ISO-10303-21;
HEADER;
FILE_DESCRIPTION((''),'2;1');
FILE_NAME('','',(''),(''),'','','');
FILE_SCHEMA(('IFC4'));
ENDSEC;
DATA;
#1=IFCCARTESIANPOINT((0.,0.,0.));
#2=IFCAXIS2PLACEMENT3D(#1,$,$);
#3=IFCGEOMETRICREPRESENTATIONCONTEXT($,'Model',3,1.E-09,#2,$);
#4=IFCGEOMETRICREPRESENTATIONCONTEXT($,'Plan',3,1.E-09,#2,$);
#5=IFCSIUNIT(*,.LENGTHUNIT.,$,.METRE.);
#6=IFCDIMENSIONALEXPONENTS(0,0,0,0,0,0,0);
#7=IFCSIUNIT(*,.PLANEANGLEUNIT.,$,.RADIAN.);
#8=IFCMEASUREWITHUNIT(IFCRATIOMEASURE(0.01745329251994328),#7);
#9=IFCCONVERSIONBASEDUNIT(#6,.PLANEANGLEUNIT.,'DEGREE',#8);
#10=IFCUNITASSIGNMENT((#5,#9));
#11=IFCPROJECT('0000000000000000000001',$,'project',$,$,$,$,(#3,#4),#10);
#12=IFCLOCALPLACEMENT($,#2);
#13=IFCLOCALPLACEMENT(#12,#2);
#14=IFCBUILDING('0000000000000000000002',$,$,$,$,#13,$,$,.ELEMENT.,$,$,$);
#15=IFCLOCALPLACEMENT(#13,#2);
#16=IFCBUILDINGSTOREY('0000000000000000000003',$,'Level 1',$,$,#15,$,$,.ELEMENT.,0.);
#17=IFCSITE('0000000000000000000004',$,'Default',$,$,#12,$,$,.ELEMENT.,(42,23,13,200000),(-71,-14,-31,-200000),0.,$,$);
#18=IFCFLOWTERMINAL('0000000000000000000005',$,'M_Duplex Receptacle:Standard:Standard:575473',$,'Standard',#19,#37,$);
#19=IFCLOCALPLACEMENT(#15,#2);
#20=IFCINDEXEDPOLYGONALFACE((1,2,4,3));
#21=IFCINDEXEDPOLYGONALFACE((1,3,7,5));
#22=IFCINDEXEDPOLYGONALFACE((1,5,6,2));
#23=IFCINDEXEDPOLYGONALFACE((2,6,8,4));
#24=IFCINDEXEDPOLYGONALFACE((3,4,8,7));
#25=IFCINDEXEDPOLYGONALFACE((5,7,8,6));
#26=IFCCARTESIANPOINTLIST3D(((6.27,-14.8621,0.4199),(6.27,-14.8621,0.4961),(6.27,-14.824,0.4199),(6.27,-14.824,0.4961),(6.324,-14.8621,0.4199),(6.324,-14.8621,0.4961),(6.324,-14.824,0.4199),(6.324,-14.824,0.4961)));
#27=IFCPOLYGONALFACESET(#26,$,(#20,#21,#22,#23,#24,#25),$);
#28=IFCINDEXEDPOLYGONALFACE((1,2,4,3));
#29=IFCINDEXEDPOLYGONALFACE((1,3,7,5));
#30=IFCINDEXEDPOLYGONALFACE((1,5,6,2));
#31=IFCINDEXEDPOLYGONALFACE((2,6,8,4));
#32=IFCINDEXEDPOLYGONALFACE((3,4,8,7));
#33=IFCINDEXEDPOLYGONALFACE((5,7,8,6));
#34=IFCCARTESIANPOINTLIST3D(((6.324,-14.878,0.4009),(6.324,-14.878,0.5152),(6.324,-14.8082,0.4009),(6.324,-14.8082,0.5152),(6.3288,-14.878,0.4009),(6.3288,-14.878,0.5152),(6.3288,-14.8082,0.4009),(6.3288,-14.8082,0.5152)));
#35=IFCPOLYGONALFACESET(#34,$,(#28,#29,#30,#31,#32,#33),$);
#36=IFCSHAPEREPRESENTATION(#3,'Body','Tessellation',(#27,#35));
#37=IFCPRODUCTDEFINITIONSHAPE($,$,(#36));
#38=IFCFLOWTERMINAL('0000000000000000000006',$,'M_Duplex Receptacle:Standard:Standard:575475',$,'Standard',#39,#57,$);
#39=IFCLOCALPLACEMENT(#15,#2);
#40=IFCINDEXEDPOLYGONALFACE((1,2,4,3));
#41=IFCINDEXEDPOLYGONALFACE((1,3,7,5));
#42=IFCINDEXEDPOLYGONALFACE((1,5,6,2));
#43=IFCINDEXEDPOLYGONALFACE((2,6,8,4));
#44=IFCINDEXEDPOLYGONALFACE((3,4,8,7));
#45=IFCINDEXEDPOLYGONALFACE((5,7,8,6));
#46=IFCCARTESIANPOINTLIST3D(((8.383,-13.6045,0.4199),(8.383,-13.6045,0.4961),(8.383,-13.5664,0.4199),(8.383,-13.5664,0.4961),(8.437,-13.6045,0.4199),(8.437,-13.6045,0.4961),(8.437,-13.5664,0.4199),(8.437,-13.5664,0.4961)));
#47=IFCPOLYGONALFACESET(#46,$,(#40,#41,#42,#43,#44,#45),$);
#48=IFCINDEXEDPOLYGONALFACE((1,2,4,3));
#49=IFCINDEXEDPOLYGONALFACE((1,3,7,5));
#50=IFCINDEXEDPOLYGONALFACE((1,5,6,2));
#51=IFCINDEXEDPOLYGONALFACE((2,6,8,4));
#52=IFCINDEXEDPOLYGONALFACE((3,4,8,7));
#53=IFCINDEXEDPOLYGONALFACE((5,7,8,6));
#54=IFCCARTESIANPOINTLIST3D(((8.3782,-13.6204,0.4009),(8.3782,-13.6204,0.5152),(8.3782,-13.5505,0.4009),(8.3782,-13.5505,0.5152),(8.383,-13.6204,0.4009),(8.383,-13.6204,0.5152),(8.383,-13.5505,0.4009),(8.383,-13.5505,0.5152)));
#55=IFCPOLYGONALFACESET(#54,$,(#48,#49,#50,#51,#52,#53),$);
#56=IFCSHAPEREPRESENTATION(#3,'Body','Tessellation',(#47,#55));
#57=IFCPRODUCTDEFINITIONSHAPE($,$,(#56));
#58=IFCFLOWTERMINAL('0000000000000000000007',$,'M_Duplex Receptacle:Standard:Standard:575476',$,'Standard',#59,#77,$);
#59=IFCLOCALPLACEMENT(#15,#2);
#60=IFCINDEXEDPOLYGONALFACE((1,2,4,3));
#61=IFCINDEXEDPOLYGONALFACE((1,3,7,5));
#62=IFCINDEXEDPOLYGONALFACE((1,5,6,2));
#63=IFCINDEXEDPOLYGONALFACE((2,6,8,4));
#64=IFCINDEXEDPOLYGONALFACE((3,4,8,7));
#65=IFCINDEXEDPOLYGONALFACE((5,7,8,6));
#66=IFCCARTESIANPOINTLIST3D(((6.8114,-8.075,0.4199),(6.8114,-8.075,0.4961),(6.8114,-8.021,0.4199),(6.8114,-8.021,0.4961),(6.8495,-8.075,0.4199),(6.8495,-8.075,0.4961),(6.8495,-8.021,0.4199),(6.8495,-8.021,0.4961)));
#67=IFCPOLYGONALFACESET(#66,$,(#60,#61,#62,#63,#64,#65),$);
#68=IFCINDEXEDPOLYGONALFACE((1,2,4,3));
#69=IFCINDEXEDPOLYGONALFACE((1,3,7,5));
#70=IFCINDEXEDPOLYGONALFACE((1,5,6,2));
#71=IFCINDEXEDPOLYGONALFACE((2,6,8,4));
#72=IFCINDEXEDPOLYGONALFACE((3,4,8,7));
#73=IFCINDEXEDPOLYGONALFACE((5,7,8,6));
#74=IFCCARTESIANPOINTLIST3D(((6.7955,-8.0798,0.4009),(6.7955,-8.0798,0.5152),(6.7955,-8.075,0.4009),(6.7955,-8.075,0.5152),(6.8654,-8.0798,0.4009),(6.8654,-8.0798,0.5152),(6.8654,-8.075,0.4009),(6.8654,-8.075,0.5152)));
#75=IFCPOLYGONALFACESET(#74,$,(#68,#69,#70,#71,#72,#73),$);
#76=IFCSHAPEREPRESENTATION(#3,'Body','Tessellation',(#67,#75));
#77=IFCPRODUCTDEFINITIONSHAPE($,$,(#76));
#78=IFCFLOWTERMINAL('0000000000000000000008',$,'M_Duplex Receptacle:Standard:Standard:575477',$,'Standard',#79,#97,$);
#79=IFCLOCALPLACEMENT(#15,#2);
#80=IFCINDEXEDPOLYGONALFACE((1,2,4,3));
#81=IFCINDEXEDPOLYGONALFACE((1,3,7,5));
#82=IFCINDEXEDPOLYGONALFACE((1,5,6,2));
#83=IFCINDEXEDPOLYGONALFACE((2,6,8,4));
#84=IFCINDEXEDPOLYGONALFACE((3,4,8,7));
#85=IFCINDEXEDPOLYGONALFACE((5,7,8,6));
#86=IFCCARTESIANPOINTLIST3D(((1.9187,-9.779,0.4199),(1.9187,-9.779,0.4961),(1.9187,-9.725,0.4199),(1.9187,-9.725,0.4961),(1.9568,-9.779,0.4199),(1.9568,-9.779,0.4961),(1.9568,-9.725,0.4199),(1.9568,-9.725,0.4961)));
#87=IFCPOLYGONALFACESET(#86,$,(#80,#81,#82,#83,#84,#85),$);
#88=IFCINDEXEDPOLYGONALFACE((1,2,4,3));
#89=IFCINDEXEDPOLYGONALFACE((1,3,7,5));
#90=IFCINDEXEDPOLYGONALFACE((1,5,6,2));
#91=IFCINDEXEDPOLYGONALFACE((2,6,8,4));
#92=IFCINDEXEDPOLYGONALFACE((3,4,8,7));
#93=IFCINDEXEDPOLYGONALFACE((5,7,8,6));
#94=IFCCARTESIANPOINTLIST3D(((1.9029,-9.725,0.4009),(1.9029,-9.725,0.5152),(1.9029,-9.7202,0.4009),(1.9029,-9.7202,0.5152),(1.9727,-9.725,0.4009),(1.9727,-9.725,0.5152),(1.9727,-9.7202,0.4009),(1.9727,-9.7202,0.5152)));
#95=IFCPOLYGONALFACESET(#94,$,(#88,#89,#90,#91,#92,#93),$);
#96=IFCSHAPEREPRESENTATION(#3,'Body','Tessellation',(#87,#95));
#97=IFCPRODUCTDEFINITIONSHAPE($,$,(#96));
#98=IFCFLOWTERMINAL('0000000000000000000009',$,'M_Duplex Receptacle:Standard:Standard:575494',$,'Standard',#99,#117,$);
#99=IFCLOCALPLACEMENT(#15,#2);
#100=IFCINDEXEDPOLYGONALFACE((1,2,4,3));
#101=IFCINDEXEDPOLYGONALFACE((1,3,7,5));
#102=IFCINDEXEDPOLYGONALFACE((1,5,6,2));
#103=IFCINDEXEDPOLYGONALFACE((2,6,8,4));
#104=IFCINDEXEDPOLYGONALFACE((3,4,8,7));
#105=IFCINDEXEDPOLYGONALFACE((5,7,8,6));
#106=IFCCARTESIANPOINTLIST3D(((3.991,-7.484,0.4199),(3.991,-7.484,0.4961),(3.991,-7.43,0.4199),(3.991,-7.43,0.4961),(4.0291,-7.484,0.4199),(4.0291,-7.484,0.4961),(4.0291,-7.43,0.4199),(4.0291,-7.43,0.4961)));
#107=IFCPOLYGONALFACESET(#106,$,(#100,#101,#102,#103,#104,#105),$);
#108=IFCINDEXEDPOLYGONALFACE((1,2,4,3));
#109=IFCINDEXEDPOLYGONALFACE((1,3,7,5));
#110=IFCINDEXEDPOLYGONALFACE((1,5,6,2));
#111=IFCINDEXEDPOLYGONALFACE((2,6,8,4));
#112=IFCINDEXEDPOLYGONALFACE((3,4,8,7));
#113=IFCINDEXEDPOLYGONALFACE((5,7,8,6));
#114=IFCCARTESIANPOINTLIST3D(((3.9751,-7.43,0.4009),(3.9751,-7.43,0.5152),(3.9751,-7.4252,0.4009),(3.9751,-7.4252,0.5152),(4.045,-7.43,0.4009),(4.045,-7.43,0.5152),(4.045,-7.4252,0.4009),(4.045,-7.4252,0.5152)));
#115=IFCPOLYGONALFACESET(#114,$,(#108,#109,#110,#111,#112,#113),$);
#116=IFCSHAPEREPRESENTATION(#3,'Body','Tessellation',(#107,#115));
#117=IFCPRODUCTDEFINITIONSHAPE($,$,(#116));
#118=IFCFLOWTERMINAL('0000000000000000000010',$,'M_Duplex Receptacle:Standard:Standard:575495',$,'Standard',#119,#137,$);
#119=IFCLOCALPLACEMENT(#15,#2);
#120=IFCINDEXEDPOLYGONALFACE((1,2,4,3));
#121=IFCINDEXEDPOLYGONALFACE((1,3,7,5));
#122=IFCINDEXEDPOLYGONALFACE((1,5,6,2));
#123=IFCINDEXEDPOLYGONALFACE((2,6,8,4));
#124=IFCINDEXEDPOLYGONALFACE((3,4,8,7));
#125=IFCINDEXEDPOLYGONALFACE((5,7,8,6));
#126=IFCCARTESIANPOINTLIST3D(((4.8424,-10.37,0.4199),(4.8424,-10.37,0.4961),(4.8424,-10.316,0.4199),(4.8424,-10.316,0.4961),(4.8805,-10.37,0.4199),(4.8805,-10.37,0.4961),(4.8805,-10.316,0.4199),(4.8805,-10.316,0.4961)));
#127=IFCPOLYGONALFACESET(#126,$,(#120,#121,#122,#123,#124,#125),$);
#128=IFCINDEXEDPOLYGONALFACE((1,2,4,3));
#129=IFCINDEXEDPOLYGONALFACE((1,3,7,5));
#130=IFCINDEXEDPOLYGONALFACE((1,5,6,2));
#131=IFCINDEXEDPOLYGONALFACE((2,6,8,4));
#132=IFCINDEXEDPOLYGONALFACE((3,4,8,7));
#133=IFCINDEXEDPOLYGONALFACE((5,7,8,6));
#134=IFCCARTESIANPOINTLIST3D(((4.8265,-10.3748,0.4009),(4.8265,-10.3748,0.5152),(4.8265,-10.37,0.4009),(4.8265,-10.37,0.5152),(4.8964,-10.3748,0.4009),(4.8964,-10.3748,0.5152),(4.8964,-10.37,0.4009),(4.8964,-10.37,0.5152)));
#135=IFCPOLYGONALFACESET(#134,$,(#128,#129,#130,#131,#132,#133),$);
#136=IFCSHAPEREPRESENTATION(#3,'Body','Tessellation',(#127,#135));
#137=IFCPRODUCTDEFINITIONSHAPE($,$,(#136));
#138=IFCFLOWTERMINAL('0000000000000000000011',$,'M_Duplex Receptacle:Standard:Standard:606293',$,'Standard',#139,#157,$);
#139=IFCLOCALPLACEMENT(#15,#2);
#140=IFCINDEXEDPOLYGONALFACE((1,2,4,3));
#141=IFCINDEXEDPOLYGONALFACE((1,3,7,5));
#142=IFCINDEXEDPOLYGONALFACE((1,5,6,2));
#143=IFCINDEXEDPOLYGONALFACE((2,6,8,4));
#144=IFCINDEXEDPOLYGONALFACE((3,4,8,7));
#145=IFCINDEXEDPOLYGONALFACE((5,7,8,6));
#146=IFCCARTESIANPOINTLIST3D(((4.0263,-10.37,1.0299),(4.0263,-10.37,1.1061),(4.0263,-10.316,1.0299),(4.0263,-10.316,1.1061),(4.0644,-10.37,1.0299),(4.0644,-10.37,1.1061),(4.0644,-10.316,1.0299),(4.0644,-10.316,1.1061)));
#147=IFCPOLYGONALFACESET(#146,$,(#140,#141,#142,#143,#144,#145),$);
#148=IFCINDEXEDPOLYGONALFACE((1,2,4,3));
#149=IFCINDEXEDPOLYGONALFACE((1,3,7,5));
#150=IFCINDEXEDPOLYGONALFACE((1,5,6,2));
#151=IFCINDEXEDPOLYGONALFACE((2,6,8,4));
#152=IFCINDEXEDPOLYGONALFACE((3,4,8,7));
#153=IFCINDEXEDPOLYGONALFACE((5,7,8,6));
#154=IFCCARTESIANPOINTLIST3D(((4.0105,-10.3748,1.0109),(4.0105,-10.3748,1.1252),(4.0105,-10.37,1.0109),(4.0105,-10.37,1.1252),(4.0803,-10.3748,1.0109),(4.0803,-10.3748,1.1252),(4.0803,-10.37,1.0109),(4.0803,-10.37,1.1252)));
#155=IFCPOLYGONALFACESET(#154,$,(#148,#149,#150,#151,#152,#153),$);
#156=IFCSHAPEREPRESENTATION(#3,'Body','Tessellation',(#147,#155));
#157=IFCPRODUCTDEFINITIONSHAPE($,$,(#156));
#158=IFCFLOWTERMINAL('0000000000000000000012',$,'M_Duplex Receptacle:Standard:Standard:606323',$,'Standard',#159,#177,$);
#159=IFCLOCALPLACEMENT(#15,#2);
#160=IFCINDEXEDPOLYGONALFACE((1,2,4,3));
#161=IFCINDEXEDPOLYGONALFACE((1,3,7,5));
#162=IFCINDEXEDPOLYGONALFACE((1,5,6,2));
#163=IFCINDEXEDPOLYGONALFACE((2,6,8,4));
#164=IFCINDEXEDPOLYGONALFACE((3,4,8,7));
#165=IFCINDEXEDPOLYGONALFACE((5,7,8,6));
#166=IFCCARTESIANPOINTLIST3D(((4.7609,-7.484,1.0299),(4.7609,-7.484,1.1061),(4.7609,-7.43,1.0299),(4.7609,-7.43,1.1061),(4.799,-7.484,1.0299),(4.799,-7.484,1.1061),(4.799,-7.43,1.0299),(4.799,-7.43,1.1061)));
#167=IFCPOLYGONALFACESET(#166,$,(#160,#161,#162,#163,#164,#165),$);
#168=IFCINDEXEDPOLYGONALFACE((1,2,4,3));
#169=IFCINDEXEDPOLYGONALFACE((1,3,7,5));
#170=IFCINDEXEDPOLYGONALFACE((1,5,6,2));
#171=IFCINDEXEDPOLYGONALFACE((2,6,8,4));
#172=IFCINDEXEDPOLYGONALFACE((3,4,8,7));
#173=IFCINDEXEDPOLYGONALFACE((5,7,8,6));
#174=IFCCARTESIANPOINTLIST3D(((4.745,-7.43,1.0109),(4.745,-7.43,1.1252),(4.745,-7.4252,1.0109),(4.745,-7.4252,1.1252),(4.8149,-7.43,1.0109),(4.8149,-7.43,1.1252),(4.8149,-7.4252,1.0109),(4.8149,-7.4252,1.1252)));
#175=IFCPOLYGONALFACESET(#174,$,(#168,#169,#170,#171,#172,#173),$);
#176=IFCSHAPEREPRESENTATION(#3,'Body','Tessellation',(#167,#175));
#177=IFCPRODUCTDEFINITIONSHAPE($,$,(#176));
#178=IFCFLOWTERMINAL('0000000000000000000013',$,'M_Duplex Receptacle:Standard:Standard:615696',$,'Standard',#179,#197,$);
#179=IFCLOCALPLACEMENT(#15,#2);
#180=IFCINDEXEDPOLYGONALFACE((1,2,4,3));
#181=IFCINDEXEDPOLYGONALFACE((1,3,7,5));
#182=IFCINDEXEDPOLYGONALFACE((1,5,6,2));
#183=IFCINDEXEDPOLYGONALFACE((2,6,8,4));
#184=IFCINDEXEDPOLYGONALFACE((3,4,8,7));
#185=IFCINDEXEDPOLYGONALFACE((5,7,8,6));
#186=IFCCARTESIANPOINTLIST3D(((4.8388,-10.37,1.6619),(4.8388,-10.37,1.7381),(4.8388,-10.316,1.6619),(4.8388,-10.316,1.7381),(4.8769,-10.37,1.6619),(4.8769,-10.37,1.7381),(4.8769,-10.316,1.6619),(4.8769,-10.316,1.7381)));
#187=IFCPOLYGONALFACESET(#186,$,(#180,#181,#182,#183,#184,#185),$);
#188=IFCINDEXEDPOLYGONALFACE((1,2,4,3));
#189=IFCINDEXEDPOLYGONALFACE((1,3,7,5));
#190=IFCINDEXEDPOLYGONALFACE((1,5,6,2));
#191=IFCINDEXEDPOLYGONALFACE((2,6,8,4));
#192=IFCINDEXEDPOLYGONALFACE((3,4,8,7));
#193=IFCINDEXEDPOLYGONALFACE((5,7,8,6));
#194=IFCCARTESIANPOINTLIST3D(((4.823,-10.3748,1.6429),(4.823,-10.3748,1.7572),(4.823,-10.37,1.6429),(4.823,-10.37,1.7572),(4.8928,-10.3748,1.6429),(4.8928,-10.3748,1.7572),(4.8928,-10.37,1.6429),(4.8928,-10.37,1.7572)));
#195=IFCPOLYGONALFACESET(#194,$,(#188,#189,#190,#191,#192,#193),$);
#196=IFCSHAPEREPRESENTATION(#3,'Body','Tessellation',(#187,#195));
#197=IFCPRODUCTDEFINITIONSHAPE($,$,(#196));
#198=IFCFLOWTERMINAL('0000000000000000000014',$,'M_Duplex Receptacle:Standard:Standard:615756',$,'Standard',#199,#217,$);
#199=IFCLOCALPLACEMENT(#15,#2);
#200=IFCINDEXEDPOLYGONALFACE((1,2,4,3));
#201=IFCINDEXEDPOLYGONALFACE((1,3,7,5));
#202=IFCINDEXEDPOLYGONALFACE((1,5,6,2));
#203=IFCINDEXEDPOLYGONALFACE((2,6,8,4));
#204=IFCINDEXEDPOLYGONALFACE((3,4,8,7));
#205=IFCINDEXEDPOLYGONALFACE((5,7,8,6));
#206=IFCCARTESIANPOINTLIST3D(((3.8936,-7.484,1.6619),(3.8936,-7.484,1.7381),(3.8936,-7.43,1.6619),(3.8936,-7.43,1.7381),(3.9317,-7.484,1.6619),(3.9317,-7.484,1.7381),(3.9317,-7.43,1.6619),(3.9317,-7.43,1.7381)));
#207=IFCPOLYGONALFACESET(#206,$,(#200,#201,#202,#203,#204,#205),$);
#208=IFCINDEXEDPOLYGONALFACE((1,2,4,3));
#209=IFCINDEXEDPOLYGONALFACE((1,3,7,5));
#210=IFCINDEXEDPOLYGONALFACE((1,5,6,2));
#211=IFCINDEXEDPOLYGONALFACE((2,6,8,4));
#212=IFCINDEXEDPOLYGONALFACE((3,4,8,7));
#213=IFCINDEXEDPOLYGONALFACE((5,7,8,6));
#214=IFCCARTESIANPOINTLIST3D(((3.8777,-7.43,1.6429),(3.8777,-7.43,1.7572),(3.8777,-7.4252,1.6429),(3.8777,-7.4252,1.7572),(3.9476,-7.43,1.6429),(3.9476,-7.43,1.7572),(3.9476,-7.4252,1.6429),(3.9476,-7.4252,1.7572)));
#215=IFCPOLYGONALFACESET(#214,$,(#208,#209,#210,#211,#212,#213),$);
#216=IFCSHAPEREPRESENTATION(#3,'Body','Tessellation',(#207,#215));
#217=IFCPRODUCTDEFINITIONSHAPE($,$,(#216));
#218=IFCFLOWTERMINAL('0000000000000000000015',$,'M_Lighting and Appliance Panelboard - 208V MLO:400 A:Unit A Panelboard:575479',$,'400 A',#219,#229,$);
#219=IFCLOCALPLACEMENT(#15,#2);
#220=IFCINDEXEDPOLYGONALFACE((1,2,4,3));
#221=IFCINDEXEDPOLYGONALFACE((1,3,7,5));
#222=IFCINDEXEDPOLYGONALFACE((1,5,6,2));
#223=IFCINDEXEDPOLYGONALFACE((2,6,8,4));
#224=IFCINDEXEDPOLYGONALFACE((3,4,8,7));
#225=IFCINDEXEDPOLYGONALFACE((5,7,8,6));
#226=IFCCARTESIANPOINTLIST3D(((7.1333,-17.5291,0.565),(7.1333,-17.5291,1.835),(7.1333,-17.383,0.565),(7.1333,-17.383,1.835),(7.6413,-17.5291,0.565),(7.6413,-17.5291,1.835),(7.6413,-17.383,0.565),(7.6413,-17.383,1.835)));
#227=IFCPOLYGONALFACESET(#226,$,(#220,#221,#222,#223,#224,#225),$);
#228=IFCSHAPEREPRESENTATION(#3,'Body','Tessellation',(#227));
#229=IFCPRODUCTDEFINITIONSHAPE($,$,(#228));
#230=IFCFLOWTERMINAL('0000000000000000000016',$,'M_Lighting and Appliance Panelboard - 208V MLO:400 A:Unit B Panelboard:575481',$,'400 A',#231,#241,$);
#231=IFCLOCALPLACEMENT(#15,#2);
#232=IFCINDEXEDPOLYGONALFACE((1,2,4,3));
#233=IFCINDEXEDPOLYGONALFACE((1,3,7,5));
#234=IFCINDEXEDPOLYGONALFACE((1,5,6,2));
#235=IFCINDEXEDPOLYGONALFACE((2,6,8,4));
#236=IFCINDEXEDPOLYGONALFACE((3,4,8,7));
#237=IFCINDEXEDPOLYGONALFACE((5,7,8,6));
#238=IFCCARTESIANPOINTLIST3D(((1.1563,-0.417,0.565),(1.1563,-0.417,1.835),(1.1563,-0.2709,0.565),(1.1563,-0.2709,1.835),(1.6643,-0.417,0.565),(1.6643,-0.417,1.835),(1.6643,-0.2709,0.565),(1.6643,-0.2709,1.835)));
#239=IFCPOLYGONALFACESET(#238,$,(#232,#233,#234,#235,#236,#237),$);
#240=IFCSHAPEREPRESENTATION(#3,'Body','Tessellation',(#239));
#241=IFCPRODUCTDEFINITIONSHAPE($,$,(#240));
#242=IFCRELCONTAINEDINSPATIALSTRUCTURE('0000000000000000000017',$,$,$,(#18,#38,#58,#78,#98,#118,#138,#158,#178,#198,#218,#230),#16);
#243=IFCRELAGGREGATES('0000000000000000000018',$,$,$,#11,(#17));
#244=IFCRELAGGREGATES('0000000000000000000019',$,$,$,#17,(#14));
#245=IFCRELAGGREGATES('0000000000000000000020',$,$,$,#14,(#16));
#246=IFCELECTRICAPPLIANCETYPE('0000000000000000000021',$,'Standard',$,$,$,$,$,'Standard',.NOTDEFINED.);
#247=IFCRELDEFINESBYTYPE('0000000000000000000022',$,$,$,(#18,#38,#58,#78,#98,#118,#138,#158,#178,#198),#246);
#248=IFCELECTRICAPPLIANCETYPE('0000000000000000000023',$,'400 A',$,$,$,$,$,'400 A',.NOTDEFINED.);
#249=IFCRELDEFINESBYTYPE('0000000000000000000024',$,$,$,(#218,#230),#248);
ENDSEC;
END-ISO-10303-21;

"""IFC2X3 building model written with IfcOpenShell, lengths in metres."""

from ifc_helpers import new_model, entity, si_unit, converted_unit, frame, origin, origin_2d_with_axis, place, context, project, spatial, rectangle, extrude, source, transform, mapped, type_object, type_shapes, element, save


model = new_model("IFC2X3")

# Units and contexts
model_context = context("Model", 3, precision=1e-09, world=origin())
plan_context = context("Plan", 3, precision=1e-09, world=origin())
ifc_project = project(units=[si_unit("LENGTHUNIT", "METRE"), converted_unit("PLANEANGLEUNIT", "DEGREE", entity("IfcRatioMeasure", 0.01745329251994328), si_unit("PLANEANGLEUNIT", "RADIAN"), dimensions=[0, 0, 0, 0, 0, 0, 0])], contexts=[model_context, plan_context])

# Site, building, storey
site_placement = place(None, origin())
site = spatial("IfcSite", under=ifc_project, at=site_placement, Name="Default", CompositionType="ELEMENT", RefLatitude=(42, 23, 13, 200000), RefLongitude=(-71, -14, -31, -200000), RefElevation=0.0)
building_placement = place(site_placement, origin())
building = spatial("IfcBuilding", under=site, at=building_placement, CompositionType="ELEMENT")
storey_placement = place(building_placement, origin())
storey = spatial("IfcBuildingStorey", under=building, at=storey_placement, Name="Level 1", CompositionType="ELEMENT", Elevation=0.0)

# Flow terminals
electric_appliance_type_1 = type_object("IfcElectricApplianceType", Name="Standard", ElementType="Standard", PredefinedType="NOTDEFINED")
shared_shape_1 = source(origin(), model_context, "Body", "SweptSolid", [
    extrude(rectangle(XDim=0.0381, YDim=0.0762, at=origin_2d_with_axis()), frame((0.0, 0.0, -0.054), z_axis=(0.0, 0.0, 1.0), x_axis=(-1.0, 0.0, 0.0)), (0.0, 0.0, 1.0), 0.054),
    extrude(rectangle(XDim=0.0698, YDim=0.1143, at=origin_2d_with_axis()), frame((0.0, 0.0, 0.0), z_axis=(0.0, 0.0, 1.0), x_axis=(-1.0, 0.0, 0.0)), (0.0, 0.0, 1.0), 0.0048),
])
type_shapes(electric_appliance_type_1, [shared_shape_1])
for number, where, z_axis, x_axis, name in (
    (1, (6.324, -14.8431, 0.458), (1.0, 0.0, 0.0), (0.0, 1.0, 0.0), "M_Duplex Receptacle:Standard:Standard:575473"),
    (2, (8.383, -13.5854, 0.458), (-1.0, 0.0, 0.0), (0.0, -1.0, 0.0), "M_Duplex Receptacle:Standard:Standard:575475"),
    (3, (6.8305, -8.075, 0.458), (0.0, -1.0, 0.0), (1.0, 0.0, 0.0), "M_Duplex Receptacle:Standard:Standard:575476"),
    (4, (1.9378, -9.725, 0.458), (0.0, 1.0, 0.0), (-1.0, 0.0, 0.0), "M_Duplex Receptacle:Standard:Standard:575477"),
    (5, (4.0101, -7.43, 0.458), (0.0, 1.0, 0.0), (-1.0, 0.0, 0.0), "M_Duplex Receptacle:Standard:Standard:575494"),
    (6, (4.8615, -10.37, 0.458), (0.0, -1.0, 0.0), (1.0, 0.0, 0.0), "M_Duplex Receptacle:Standard:Standard:575495"),
    (7, (4.0454, -10.37, 1.068), (0.0, -1.0, 0.0), (1.0, 0.0, 0.0), "M_Duplex Receptacle:Standard:Standard:606293"),
    (8, (4.78, -7.43, 1.068), (0.0, 1.0, 0.0), (-1.0, 0.0, 0.0), "M_Duplex Receptacle:Standard:Standard:606323"),
    (9, (4.8579, -10.37, 1.7), (0.0, -1.0, 0.0), (1.0, 0.0, 0.0), "M_Duplex Receptacle:Standard:Standard:615696"),
    (10, (3.9127, -7.43, 1.7), (0.0, 1.0, 0.0), (-1.0, 0.0, 0.0), "M_Duplex Receptacle:Standard:Standard:615756"),
):
    element("IfcFlowTerminal", number, at=place(storey_placement, frame(where, z_axis=z_axis, x_axis=x_axis)), inside=storey, type_object=electric_appliance_type_1, Name=name, ObjectType="Standard", context=model_context, shape_type="MappedRepresentation", body=[
        mapped(shared_shape_1, transform((0.0, 0.0, 0.0), scale=1.0)),
    ])
electric_appliance_type_2 = type_object("IfcElectricApplianceType", Name="400 A", ElementType="400 A", PredefinedType="NOTDEFINED")
shared_shape_2 = source(origin(), model_context, "Body", "SweptSolid", [
    extrude(rectangle(XDim=0.508, YDim=1.27, at=origin_2d_with_axis()), frame((0.0, -0.4191, -0.1461), z_axis=(0.0, 0.0, 1.0), x_axis=(-1.0, 0.0, 0.0)), (0.0, 0.0, 1.0), 0.1461),
])
type_shapes(electric_appliance_type_2, [shared_shape_2])
for number, where, z_axis, x_axis, name in (
    (11, (7.3873, -17.383, 1.6191), (0.0, 1.0, 0.0), (-1.0, 0.0, 0.0), "M_Lighting and Appliance Panelboard - 208V MLO:400 A:Unit A Panelboard:575479"),
    (12, (1.4103, -0.417, 1.6191), (0.0, -1.0, 0.0), (1.0, 0.0, 0.0), "M_Lighting and Appliance Panelboard - 208V MLO:400 A:Unit B Panelboard:575481"),
):
    element("IfcFlowTerminal", number, at=place(storey_placement, frame(where, z_axis=z_axis, x_axis=x_axis)), inside=storey, type_object=electric_appliance_type_2, Name=name, ObjectType="400 A", context=model_context, shape_type="MappedRepresentation", body=[
        mapped(shared_shape_2, transform((0.0, 0.0, 0.0), scale=1.0)),
    ])

save(model, "model.ifc")
